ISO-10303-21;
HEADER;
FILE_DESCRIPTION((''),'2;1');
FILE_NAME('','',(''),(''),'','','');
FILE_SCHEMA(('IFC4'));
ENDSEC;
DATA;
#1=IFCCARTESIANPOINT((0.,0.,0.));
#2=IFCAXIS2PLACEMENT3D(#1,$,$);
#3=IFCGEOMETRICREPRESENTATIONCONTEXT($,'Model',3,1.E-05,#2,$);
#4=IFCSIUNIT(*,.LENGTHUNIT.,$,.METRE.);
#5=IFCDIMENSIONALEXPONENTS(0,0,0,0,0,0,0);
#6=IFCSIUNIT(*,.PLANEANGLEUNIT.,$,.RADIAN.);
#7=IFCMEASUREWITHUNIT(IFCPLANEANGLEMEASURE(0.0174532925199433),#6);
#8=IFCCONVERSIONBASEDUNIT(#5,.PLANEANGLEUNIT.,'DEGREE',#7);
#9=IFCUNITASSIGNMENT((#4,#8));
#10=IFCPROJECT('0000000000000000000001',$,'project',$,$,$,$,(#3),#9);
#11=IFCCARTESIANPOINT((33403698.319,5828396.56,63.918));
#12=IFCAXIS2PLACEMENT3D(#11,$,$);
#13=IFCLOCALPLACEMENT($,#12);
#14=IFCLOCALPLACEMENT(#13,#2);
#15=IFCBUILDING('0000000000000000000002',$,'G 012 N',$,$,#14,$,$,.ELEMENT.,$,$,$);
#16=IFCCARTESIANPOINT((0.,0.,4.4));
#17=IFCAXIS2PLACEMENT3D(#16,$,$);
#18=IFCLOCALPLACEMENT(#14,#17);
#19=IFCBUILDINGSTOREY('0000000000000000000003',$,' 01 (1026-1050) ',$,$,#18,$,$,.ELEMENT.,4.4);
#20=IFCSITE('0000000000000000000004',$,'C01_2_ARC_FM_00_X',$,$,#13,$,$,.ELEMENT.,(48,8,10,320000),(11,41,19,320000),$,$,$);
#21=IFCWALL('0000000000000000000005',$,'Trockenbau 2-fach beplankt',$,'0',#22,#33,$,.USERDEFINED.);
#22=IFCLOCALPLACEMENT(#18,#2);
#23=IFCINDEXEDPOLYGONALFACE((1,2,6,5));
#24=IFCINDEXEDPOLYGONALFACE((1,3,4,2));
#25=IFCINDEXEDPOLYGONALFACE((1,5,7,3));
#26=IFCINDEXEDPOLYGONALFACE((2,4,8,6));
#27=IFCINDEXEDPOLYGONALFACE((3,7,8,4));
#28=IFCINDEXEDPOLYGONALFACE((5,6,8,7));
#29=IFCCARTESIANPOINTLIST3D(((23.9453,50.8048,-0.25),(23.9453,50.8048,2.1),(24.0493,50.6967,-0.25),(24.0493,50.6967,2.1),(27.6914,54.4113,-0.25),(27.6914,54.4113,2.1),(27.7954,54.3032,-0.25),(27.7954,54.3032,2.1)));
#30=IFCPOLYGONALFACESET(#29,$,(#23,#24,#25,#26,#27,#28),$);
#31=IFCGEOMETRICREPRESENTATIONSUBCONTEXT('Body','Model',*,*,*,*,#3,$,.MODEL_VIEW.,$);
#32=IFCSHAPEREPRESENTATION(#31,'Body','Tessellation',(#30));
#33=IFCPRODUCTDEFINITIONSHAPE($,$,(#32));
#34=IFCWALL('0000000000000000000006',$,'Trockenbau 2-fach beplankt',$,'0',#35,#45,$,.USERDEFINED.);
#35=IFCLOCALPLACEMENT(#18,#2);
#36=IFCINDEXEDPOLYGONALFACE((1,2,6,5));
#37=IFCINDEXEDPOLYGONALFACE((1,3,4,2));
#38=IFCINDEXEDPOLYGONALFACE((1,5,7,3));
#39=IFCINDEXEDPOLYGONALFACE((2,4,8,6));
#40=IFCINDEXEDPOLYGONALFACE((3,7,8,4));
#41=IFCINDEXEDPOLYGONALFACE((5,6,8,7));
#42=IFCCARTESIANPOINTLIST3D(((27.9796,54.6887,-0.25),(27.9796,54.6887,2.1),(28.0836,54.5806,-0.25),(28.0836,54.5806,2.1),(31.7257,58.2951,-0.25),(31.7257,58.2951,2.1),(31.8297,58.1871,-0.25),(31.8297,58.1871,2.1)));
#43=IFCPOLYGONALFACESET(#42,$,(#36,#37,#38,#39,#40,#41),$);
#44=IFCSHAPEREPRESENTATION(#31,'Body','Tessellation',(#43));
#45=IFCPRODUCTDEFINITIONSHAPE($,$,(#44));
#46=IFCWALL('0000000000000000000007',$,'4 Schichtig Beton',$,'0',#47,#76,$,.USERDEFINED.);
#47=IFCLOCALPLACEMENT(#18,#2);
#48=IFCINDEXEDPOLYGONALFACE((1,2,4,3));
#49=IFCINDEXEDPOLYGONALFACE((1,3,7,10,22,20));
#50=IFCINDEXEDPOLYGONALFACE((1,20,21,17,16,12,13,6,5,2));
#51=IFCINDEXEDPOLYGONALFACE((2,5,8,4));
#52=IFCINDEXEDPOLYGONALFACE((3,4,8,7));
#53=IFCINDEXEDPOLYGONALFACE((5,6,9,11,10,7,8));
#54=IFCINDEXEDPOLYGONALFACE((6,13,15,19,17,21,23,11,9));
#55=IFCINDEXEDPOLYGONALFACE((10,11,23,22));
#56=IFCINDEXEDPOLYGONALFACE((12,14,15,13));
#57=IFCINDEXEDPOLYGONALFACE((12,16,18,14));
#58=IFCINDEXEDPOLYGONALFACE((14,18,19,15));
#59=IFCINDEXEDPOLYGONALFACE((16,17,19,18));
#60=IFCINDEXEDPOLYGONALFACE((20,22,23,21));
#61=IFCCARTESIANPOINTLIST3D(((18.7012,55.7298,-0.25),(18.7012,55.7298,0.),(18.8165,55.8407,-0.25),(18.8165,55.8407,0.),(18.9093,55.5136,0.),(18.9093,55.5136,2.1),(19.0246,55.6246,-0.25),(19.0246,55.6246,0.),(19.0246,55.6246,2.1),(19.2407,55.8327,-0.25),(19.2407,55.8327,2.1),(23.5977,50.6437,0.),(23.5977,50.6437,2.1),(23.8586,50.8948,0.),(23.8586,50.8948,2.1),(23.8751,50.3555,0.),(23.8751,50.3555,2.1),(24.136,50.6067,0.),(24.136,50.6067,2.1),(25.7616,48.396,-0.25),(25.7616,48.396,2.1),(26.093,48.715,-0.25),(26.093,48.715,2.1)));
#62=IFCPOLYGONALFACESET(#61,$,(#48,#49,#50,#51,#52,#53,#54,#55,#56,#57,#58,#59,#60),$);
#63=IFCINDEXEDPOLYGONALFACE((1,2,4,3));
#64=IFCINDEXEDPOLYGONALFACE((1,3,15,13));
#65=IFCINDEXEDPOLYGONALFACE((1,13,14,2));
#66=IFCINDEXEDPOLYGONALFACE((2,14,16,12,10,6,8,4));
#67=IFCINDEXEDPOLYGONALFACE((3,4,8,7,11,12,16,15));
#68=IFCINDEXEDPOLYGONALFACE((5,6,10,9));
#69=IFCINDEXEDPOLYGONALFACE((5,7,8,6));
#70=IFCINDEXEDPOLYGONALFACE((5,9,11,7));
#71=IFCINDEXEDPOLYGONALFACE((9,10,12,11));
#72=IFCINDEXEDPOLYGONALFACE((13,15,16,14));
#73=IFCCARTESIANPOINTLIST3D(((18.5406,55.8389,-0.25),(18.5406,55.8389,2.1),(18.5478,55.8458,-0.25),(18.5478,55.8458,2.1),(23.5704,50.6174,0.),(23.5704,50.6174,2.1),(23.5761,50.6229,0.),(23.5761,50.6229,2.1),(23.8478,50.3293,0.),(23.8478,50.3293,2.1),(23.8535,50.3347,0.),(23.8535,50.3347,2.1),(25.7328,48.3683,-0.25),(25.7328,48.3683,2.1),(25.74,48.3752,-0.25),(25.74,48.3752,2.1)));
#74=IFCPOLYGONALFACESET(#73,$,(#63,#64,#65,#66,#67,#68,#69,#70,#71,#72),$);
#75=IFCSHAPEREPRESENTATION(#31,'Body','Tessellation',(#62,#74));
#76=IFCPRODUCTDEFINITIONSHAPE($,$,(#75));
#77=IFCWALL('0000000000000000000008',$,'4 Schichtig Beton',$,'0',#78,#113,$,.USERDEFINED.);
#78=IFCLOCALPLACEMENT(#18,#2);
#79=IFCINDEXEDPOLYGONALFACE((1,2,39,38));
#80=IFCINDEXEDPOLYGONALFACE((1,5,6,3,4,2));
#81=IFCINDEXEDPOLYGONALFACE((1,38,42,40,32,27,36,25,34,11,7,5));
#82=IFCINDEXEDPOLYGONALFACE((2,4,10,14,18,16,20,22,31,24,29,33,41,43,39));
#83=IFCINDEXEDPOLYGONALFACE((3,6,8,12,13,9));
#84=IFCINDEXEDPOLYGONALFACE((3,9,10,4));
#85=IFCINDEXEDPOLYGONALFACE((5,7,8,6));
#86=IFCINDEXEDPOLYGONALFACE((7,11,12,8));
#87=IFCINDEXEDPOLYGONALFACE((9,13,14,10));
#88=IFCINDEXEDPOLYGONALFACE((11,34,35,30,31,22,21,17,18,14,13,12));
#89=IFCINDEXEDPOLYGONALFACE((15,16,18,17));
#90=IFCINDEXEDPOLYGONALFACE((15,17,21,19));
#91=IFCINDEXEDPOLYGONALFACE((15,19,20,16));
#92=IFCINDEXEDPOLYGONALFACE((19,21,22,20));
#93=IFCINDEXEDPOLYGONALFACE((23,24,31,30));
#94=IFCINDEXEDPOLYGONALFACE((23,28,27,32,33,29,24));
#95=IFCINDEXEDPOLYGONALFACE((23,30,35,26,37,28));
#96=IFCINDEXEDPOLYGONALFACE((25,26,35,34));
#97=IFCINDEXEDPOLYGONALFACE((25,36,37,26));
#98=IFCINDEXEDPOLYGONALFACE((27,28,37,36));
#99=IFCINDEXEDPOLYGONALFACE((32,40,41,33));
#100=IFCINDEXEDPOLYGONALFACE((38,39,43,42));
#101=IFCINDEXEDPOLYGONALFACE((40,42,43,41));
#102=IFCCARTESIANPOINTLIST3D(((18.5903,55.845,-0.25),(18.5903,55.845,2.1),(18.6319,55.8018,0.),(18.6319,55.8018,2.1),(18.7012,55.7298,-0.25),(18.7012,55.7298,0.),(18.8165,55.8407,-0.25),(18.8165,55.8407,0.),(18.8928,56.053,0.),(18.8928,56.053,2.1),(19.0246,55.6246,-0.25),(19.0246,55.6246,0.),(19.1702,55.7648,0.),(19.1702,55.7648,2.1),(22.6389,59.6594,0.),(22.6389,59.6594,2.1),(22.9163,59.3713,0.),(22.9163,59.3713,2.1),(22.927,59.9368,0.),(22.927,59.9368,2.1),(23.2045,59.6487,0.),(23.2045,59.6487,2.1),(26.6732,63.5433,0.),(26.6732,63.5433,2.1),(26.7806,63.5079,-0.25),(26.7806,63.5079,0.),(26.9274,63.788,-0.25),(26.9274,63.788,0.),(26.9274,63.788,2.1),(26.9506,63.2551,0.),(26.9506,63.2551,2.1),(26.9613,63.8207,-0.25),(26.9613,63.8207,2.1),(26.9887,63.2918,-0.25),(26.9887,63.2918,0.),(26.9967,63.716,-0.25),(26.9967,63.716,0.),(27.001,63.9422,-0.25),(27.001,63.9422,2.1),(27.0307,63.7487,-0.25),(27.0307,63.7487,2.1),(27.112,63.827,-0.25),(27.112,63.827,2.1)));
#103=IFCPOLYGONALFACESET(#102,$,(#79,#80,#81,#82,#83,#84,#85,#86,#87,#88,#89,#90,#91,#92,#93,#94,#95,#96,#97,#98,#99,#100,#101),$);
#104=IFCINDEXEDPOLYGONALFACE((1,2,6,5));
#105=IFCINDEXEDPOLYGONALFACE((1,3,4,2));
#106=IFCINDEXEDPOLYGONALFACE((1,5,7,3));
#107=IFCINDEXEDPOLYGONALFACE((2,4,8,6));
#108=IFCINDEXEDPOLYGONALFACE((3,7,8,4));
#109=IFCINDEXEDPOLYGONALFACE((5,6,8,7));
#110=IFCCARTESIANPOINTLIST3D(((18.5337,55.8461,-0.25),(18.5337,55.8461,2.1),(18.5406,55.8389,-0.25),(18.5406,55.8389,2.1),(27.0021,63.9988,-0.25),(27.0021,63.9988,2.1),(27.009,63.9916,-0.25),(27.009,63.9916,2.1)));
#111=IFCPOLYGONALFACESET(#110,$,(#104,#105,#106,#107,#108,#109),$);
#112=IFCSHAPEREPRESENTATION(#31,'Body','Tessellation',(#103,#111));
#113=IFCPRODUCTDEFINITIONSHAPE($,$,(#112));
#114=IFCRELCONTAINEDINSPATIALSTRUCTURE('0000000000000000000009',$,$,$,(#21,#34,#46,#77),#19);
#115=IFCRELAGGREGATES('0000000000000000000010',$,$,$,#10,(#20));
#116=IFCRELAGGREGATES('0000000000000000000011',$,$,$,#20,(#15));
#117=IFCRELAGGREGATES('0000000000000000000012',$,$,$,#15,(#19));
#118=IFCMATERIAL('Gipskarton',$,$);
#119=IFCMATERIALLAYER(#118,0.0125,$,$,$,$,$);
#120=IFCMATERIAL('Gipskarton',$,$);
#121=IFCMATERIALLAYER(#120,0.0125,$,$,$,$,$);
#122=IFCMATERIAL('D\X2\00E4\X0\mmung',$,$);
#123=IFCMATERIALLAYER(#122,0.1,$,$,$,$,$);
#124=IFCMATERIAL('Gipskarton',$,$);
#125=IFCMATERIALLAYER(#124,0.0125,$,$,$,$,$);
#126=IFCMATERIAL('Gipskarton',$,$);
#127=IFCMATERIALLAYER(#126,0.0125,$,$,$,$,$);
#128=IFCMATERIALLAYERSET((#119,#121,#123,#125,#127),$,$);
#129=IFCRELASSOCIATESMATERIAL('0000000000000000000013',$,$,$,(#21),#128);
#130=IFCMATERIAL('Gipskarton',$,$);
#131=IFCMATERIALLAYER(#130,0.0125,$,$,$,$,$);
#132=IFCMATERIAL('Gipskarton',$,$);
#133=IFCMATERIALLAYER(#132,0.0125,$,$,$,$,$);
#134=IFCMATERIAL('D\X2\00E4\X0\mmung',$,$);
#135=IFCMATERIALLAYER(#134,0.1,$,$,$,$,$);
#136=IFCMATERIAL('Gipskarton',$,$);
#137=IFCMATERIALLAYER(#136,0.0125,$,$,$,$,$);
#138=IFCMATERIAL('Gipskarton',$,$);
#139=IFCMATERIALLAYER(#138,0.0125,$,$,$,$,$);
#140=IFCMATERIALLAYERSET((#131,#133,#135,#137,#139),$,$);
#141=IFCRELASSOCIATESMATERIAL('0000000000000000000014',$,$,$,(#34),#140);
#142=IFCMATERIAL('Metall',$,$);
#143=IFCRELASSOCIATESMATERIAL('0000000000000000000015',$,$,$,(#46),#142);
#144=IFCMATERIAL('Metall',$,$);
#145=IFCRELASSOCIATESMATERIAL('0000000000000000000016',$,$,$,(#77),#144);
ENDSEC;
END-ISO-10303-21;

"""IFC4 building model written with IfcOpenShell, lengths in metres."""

from ifc_helpers import new_model, entity, si_unit, converted_unit, frame, frame_2d, origin, origin_with_axes, place, context, subcontext, project, spatial, polyline, rectangle, outline, extrude, clip, bounded_halfspace, material, layer, layer_set, layer_usage, element, save


model = new_model("IFC4")

# Units and contexts
model_context = context("Model", 3, precision=1e-05, world=origin())
body_context = subcontext(model_context, "Body", "Model", "MODEL_VIEW")
ifc_project = project(units=[si_unit("LENGTHUNIT", "METRE"), converted_unit("PLANEANGLEUNIT", "DEGREE", entity("IfcPlaneAngleMeasure", 0.0174532925199433), si_unit("PLANEANGLEUNIT", "RADIAN"), dimensions=[0, 0, 0, 0, 0, 0, 0])], contexts=[model_context])

# Site, building, storey
site_placement = place(None, frame((33403698.319, 5828396.56, 63.918)))
site = spatial("IfcSite", under=ifc_project, at=site_placement, Name="C01_2_ARC_FM_00_X", CompositionType="ELEMENT", RefLatitude=(48, 8, 10, 320000), RefLongitude=(11, 41, 19, 320000))
building_placement = place(site_placement, origin())
building = spatial("IfcBuilding", under=site, at=building_placement, Name="G 012 N", CompositionType="ELEMENT")
storey_placement = place(building_placement, frame((0.0, 0.0, 4.4)))
storey = spatial("IfcBuildingStorey", under=building, at=storey_placement, Name=" 01 (1026-1050) ", CompositionType="ELEMENT", Elevation=4.4)

# Walls
ifc_material_1 = material(Name="Gipskarton")
ifc_layer_1 = layer(ifc_material_1, 0.0125)
ifc_material_2 = material(Name="Gipskarton")
ifc_layer_2 = layer(ifc_material_2, 0.0125)
ifc_material_3 = material(Name="Dämmung")
ifc_layer_3 = layer(ifc_material_3, 0.1)
ifc_material_4 = material(Name="Gipskarton")
ifc_layer_4 = layer(ifc_material_4, 0.0125)
ifc_material_5 = material(Name="Gipskarton")
ifc_layer_5 = layer(ifc_material_5, 0.0125)
ifc_layer_set_1 = layer_set([ifc_layer_1, ifc_layer_2, ifc_layer_3, ifc_layer_4, ifc_layer_5])
ifc_layer_usage_1 = layer_usage(ifc_layer_set_1, "AXIS2", "POSITIVE", 0.0)
wall_1_placement = place(storey_placement, frame((27.6914, 54.4113, -0.25), z_axis=(0.0, 0.0, 1.0), x_axis=(-0.720408, -0.693551, 0.0)))
element("IfcWall", 1, at=wall_1_placement, inside=storey, material=ifc_layer_usage_1, Name="Trockenbau 2-fach beplankt", ObjectType="0", PredefinedType="USERDEFINED", context=body_context, shape_type="SweptSolid", body=[
    extrude(rectangle(XDim=5.2, YDim=0.15, at=frame_2d((2.6, 0.075), x_axis=(1.0, 0.0))), origin_with_axes(), (0.0, 0.0, 1.0), 2.35),
])
ifc_material_6 = material(Name="Gipskarton")
ifc_layer_6 = layer(ifc_material_6, 0.0125)
ifc_material_7 = material(Name="Gipskarton")
ifc_layer_7 = layer(ifc_material_7, 0.0125)
ifc_material_8 = material(Name="Dämmung")
ifc_layer_8 = layer(ifc_material_8, 0.1)
ifc_material_9 = material(Name="Gipskarton")
ifc_layer_9 = layer(ifc_material_9, 0.0125)
ifc_material_10 = material(Name="Gipskarton")
ifc_layer_10 = layer(ifc_material_10, 0.0125)
ifc_layer_set_2 = layer_set([ifc_layer_6, ifc_layer_7, ifc_layer_8, ifc_layer_9, ifc_layer_10])
ifc_layer_usage_2 = layer_usage(ifc_layer_set_2, "AXIS2", "POSITIVE", 0.0)
wall_2_placement = place(storey_placement, frame((31.7257, 58.2951, -0.25), z_axis=(0.0, 0.0, 1.0), x_axis=(-0.720408, -0.693551, 0.0)))
element("IfcWall", 2, at=wall_2_placement, inside=storey, material=ifc_layer_usage_2, Name="Trockenbau 2-fach beplankt", ObjectType="0", PredefinedType="USERDEFINED", context=body_context, shape_type="SweptSolid", body=[
    extrude(rectangle(XDim=5.2, YDim=0.15, at=frame_2d((2.6, 0.075), x_axis=(1.0, 0.0))), origin_with_axes(), (0.0, 0.0, 1.0), 2.35),
])
ifc_material_11 = material(Name="Metall")
wall_3_placement = place(storey_placement, frame((18.5406, 55.8389, -0.25), z_axis=(0.0, 0.0, 1.0), x_axis=(0.693551, -0.720408, 0.0)))
element("IfcWall", 3, at=wall_3_placement, inside=storey, material=ifc_material_11, Name="4 Schichtig Beton", ObjectType="0", PredefinedType="USERDEFINED", context=body_context, shape_type="Clipping", body=[
    clip(clip(clip(extrude(outline(polyline([(-5.2833, 5.0863), (4.8967, 5.0863), (4.8967, 5.5463), (-4.9833, 5.5463), (-4.9833, 5.2463), (-5.2833, 5.2463), (-5.2833, 5.0863)])), frame((5.4733, -5.0463, 0.0), z_axis=(0.0, 0.0, 1.0), x_axis=(1.0, 0.0, 0.0)), (0.0, 0.0, 1.0), 2.35), bounded_halfspace(frame((7.45, 0.0061, 0.25), z_axis=(0.0, 0.0, -1.0), x_axis=(1.0, 0.0, 0.0)), True, origin_with_axes(), polyline([(7.25, 0.0021), (7.65, 0.0021), (7.65, 0.01), (7.25, 0.01), (7.25, 0.0021)]))), bounded_halfspace(frame((7.45, 0.2814, 0.25), z_axis=(0.0, 0.0, -1.0), x_axis=(0.0, -1.0, 0.0)), True, origin_with_axes(), polyline([(7.25, 0.4021), (7.25, 0.04), (7.65, 0.04), (7.65, 0.4021), (7.5, 0.4021), (7.4, 0.4021), (7.25, 0.4021)]))), bounded_halfspace(frame((0.34, 0.12, 0.25), z_axis=(0.0, 0.0, -1.0), x_axis=(0.0, -1.0, 0.0)), True, origin_with_axes(), polyline([(0.19, 0.2), (0.19, 0.04), (0.49, 0.04), (0.49, 0.2), (0.19, 0.2)]))),
    clip(clip(clip(extrude(rectangle(XDim=10.37, YDim=0.01, at=frame_2d((5.185, 0.005), x_axis=(1.0, 0.0))), origin_with_axes(), (0.0, 0.0, 1.0), 2.35), bounded_halfspace(frame((7.45, 0.0061, 0.25), z_axis=(0.0, 0.0, -1.0), x_axis=(1.0, 0.0, 0.0)), True, origin_with_axes(), polyline([(7.25, 0.0021), (7.65, 0.0021), (7.65, 0.01), (7.25, 0.01), (7.25, 0.0021)]))), bounded_halfspace(frame((7.45, 0.2814, 0.25), z_axis=(0.0, 0.0, -1.0), x_axis=(0.0, -1.0, 0.0)), True, origin_with_axes(), polyline([(7.25, 0.4021), (7.25, 0.04), (7.65, 0.04), (7.65, 0.4021), (7.5, 0.4021), (7.4, 0.4021), (7.25, 0.4021)]))), bounded_halfspace(frame((0.34, 0.12, 0.25), z_axis=(0.0, 0.0, -1.0), x_axis=(0.0, -1.0, 0.0)), True, origin_with_axes(), polyline([(0.19, 0.2), (0.19, 0.04), (0.49, 0.04), (0.49, 0.2), (0.19, 0.2)]))),
])
ifc_material_12 = material(Name="Metall")
wall_4_placement = place(storey_placement, frame((27.0021, 63.9988, -0.25), z_axis=(0.0, 0.0, 1.0), x_axis=(-0.720408, -0.693551, 0.0)))
element("IfcWall", 4, at=wall_4_placement, inside=storey, material=ifc_material_12, Name="4 Schichtig Beton", ObjectType="0", PredefinedType="USERDEFINED", context=body_context, shape_type="Clipping", body=[
    clip(clip(clip(extrude(outline(polyline([(-0.3129, 0.0012), (-0.3129, 0.3012), (-11.3679, 0.3012), (-11.3679, 0.0012), (-11.6679, 0.0012), (-11.6679, -0.0988), (-11.715, -0.0988), (-11.715, 0.0012), (-11.8279, 0.0012), (-11.8279, -0.1588), (-0.1529, -0.1588), (-0.1529, 0.0012), (-0.3129, 0.0012)])), frame((11.8679, 0.1988, 0.0), z_axis=(0.0, 0.0, 1.0), x_axis=(1.0, 0.0, 0.0)), (0.0, 0.0, 1.0), 2.35), bounded_halfspace(frame((11.541, 0.2667, 0.25), z_axis=(0.0, 0.0, -1.0), x_axis=(0.0, 1.0, 0.0)), True, origin_with_axes(), polyline([(11.715, 0.1), (11.715, 0.2), (11.555, 0.2), (11.555, 0.5), (11.3529, 0.5), (11.3529, 0.1), (11.715, 0.1)]))), bounded_halfspace(frame((0.4176, 0.2667, 0.25), z_axis=(0.0, 0.0, -1.0), x_axis=(0.0, 1.0, 0.0)), True, origin_with_axes(), polyline([(0.5529, 0.1), (0.5529, 0.5), (0.5, 0.5), (0.5, 0.2), (0.2, 0.2), (0.2, 0.1), (0.5529, 0.1)]))), bounded_halfspace(frame((5.9529, 0.3, 0.25), z_axis=(0.0, 0.0, -1.0), x_axis=(0.0, 1.0, 0.0)), True, origin_with_axes(), polyline([(6.1529, 0.1), (6.1529, 0.5), (5.7529, 0.5), (5.7529, 0.1), (6.1529, 0.1)]))),
    clip(clip(clip(extrude(rectangle(XDim=11.755, YDim=0.01, at=frame_2d((-5.8775, -0.005), x_axis=(-1.0, 0.0))), frame((11.755, 0.01, 0.0), z_axis=(0.0, 0.0, 1.0), x_axis=(1.0, 0.0, 0.0)), (0.0, 0.0, 1.0), 2.35), bounded_halfspace(frame((11.541, 0.2667, 0.25), z_axis=(0.0, 0.0, -1.0), x_axis=(0.0, 1.0, 0.0)), True, origin_with_axes(), polyline([(11.715, 0.1), (11.715, 0.2), (11.555, 0.2), (11.555, 0.5), (11.3529, 0.5), (11.3529, 0.1), (11.715, 0.1)]))), bounded_halfspace(frame((0.4176, 0.2667, 0.25), z_axis=(0.0, 0.0, -1.0), x_axis=(0.0, 1.0, 0.0)), True, origin_with_axes(), polyline([(0.5529, 0.1), (0.5529, 0.5), (0.5, 0.5), (0.5, 0.2), (0.2, 0.2), (0.2, 0.1), (0.5529, 0.1)]))), bounded_halfspace(frame((5.9529, 0.3, 0.25), z_axis=(0.0, 0.0, -1.0), x_axis=(0.0, 1.0, 0.0)), True, origin_with_axes(), polyline([(6.1529, 0.1), (6.1529, 0.5), (5.7529, 0.5), (5.7529, 0.1), (6.1529, 0.1)]))),
])

save(model, "model.ifc")
